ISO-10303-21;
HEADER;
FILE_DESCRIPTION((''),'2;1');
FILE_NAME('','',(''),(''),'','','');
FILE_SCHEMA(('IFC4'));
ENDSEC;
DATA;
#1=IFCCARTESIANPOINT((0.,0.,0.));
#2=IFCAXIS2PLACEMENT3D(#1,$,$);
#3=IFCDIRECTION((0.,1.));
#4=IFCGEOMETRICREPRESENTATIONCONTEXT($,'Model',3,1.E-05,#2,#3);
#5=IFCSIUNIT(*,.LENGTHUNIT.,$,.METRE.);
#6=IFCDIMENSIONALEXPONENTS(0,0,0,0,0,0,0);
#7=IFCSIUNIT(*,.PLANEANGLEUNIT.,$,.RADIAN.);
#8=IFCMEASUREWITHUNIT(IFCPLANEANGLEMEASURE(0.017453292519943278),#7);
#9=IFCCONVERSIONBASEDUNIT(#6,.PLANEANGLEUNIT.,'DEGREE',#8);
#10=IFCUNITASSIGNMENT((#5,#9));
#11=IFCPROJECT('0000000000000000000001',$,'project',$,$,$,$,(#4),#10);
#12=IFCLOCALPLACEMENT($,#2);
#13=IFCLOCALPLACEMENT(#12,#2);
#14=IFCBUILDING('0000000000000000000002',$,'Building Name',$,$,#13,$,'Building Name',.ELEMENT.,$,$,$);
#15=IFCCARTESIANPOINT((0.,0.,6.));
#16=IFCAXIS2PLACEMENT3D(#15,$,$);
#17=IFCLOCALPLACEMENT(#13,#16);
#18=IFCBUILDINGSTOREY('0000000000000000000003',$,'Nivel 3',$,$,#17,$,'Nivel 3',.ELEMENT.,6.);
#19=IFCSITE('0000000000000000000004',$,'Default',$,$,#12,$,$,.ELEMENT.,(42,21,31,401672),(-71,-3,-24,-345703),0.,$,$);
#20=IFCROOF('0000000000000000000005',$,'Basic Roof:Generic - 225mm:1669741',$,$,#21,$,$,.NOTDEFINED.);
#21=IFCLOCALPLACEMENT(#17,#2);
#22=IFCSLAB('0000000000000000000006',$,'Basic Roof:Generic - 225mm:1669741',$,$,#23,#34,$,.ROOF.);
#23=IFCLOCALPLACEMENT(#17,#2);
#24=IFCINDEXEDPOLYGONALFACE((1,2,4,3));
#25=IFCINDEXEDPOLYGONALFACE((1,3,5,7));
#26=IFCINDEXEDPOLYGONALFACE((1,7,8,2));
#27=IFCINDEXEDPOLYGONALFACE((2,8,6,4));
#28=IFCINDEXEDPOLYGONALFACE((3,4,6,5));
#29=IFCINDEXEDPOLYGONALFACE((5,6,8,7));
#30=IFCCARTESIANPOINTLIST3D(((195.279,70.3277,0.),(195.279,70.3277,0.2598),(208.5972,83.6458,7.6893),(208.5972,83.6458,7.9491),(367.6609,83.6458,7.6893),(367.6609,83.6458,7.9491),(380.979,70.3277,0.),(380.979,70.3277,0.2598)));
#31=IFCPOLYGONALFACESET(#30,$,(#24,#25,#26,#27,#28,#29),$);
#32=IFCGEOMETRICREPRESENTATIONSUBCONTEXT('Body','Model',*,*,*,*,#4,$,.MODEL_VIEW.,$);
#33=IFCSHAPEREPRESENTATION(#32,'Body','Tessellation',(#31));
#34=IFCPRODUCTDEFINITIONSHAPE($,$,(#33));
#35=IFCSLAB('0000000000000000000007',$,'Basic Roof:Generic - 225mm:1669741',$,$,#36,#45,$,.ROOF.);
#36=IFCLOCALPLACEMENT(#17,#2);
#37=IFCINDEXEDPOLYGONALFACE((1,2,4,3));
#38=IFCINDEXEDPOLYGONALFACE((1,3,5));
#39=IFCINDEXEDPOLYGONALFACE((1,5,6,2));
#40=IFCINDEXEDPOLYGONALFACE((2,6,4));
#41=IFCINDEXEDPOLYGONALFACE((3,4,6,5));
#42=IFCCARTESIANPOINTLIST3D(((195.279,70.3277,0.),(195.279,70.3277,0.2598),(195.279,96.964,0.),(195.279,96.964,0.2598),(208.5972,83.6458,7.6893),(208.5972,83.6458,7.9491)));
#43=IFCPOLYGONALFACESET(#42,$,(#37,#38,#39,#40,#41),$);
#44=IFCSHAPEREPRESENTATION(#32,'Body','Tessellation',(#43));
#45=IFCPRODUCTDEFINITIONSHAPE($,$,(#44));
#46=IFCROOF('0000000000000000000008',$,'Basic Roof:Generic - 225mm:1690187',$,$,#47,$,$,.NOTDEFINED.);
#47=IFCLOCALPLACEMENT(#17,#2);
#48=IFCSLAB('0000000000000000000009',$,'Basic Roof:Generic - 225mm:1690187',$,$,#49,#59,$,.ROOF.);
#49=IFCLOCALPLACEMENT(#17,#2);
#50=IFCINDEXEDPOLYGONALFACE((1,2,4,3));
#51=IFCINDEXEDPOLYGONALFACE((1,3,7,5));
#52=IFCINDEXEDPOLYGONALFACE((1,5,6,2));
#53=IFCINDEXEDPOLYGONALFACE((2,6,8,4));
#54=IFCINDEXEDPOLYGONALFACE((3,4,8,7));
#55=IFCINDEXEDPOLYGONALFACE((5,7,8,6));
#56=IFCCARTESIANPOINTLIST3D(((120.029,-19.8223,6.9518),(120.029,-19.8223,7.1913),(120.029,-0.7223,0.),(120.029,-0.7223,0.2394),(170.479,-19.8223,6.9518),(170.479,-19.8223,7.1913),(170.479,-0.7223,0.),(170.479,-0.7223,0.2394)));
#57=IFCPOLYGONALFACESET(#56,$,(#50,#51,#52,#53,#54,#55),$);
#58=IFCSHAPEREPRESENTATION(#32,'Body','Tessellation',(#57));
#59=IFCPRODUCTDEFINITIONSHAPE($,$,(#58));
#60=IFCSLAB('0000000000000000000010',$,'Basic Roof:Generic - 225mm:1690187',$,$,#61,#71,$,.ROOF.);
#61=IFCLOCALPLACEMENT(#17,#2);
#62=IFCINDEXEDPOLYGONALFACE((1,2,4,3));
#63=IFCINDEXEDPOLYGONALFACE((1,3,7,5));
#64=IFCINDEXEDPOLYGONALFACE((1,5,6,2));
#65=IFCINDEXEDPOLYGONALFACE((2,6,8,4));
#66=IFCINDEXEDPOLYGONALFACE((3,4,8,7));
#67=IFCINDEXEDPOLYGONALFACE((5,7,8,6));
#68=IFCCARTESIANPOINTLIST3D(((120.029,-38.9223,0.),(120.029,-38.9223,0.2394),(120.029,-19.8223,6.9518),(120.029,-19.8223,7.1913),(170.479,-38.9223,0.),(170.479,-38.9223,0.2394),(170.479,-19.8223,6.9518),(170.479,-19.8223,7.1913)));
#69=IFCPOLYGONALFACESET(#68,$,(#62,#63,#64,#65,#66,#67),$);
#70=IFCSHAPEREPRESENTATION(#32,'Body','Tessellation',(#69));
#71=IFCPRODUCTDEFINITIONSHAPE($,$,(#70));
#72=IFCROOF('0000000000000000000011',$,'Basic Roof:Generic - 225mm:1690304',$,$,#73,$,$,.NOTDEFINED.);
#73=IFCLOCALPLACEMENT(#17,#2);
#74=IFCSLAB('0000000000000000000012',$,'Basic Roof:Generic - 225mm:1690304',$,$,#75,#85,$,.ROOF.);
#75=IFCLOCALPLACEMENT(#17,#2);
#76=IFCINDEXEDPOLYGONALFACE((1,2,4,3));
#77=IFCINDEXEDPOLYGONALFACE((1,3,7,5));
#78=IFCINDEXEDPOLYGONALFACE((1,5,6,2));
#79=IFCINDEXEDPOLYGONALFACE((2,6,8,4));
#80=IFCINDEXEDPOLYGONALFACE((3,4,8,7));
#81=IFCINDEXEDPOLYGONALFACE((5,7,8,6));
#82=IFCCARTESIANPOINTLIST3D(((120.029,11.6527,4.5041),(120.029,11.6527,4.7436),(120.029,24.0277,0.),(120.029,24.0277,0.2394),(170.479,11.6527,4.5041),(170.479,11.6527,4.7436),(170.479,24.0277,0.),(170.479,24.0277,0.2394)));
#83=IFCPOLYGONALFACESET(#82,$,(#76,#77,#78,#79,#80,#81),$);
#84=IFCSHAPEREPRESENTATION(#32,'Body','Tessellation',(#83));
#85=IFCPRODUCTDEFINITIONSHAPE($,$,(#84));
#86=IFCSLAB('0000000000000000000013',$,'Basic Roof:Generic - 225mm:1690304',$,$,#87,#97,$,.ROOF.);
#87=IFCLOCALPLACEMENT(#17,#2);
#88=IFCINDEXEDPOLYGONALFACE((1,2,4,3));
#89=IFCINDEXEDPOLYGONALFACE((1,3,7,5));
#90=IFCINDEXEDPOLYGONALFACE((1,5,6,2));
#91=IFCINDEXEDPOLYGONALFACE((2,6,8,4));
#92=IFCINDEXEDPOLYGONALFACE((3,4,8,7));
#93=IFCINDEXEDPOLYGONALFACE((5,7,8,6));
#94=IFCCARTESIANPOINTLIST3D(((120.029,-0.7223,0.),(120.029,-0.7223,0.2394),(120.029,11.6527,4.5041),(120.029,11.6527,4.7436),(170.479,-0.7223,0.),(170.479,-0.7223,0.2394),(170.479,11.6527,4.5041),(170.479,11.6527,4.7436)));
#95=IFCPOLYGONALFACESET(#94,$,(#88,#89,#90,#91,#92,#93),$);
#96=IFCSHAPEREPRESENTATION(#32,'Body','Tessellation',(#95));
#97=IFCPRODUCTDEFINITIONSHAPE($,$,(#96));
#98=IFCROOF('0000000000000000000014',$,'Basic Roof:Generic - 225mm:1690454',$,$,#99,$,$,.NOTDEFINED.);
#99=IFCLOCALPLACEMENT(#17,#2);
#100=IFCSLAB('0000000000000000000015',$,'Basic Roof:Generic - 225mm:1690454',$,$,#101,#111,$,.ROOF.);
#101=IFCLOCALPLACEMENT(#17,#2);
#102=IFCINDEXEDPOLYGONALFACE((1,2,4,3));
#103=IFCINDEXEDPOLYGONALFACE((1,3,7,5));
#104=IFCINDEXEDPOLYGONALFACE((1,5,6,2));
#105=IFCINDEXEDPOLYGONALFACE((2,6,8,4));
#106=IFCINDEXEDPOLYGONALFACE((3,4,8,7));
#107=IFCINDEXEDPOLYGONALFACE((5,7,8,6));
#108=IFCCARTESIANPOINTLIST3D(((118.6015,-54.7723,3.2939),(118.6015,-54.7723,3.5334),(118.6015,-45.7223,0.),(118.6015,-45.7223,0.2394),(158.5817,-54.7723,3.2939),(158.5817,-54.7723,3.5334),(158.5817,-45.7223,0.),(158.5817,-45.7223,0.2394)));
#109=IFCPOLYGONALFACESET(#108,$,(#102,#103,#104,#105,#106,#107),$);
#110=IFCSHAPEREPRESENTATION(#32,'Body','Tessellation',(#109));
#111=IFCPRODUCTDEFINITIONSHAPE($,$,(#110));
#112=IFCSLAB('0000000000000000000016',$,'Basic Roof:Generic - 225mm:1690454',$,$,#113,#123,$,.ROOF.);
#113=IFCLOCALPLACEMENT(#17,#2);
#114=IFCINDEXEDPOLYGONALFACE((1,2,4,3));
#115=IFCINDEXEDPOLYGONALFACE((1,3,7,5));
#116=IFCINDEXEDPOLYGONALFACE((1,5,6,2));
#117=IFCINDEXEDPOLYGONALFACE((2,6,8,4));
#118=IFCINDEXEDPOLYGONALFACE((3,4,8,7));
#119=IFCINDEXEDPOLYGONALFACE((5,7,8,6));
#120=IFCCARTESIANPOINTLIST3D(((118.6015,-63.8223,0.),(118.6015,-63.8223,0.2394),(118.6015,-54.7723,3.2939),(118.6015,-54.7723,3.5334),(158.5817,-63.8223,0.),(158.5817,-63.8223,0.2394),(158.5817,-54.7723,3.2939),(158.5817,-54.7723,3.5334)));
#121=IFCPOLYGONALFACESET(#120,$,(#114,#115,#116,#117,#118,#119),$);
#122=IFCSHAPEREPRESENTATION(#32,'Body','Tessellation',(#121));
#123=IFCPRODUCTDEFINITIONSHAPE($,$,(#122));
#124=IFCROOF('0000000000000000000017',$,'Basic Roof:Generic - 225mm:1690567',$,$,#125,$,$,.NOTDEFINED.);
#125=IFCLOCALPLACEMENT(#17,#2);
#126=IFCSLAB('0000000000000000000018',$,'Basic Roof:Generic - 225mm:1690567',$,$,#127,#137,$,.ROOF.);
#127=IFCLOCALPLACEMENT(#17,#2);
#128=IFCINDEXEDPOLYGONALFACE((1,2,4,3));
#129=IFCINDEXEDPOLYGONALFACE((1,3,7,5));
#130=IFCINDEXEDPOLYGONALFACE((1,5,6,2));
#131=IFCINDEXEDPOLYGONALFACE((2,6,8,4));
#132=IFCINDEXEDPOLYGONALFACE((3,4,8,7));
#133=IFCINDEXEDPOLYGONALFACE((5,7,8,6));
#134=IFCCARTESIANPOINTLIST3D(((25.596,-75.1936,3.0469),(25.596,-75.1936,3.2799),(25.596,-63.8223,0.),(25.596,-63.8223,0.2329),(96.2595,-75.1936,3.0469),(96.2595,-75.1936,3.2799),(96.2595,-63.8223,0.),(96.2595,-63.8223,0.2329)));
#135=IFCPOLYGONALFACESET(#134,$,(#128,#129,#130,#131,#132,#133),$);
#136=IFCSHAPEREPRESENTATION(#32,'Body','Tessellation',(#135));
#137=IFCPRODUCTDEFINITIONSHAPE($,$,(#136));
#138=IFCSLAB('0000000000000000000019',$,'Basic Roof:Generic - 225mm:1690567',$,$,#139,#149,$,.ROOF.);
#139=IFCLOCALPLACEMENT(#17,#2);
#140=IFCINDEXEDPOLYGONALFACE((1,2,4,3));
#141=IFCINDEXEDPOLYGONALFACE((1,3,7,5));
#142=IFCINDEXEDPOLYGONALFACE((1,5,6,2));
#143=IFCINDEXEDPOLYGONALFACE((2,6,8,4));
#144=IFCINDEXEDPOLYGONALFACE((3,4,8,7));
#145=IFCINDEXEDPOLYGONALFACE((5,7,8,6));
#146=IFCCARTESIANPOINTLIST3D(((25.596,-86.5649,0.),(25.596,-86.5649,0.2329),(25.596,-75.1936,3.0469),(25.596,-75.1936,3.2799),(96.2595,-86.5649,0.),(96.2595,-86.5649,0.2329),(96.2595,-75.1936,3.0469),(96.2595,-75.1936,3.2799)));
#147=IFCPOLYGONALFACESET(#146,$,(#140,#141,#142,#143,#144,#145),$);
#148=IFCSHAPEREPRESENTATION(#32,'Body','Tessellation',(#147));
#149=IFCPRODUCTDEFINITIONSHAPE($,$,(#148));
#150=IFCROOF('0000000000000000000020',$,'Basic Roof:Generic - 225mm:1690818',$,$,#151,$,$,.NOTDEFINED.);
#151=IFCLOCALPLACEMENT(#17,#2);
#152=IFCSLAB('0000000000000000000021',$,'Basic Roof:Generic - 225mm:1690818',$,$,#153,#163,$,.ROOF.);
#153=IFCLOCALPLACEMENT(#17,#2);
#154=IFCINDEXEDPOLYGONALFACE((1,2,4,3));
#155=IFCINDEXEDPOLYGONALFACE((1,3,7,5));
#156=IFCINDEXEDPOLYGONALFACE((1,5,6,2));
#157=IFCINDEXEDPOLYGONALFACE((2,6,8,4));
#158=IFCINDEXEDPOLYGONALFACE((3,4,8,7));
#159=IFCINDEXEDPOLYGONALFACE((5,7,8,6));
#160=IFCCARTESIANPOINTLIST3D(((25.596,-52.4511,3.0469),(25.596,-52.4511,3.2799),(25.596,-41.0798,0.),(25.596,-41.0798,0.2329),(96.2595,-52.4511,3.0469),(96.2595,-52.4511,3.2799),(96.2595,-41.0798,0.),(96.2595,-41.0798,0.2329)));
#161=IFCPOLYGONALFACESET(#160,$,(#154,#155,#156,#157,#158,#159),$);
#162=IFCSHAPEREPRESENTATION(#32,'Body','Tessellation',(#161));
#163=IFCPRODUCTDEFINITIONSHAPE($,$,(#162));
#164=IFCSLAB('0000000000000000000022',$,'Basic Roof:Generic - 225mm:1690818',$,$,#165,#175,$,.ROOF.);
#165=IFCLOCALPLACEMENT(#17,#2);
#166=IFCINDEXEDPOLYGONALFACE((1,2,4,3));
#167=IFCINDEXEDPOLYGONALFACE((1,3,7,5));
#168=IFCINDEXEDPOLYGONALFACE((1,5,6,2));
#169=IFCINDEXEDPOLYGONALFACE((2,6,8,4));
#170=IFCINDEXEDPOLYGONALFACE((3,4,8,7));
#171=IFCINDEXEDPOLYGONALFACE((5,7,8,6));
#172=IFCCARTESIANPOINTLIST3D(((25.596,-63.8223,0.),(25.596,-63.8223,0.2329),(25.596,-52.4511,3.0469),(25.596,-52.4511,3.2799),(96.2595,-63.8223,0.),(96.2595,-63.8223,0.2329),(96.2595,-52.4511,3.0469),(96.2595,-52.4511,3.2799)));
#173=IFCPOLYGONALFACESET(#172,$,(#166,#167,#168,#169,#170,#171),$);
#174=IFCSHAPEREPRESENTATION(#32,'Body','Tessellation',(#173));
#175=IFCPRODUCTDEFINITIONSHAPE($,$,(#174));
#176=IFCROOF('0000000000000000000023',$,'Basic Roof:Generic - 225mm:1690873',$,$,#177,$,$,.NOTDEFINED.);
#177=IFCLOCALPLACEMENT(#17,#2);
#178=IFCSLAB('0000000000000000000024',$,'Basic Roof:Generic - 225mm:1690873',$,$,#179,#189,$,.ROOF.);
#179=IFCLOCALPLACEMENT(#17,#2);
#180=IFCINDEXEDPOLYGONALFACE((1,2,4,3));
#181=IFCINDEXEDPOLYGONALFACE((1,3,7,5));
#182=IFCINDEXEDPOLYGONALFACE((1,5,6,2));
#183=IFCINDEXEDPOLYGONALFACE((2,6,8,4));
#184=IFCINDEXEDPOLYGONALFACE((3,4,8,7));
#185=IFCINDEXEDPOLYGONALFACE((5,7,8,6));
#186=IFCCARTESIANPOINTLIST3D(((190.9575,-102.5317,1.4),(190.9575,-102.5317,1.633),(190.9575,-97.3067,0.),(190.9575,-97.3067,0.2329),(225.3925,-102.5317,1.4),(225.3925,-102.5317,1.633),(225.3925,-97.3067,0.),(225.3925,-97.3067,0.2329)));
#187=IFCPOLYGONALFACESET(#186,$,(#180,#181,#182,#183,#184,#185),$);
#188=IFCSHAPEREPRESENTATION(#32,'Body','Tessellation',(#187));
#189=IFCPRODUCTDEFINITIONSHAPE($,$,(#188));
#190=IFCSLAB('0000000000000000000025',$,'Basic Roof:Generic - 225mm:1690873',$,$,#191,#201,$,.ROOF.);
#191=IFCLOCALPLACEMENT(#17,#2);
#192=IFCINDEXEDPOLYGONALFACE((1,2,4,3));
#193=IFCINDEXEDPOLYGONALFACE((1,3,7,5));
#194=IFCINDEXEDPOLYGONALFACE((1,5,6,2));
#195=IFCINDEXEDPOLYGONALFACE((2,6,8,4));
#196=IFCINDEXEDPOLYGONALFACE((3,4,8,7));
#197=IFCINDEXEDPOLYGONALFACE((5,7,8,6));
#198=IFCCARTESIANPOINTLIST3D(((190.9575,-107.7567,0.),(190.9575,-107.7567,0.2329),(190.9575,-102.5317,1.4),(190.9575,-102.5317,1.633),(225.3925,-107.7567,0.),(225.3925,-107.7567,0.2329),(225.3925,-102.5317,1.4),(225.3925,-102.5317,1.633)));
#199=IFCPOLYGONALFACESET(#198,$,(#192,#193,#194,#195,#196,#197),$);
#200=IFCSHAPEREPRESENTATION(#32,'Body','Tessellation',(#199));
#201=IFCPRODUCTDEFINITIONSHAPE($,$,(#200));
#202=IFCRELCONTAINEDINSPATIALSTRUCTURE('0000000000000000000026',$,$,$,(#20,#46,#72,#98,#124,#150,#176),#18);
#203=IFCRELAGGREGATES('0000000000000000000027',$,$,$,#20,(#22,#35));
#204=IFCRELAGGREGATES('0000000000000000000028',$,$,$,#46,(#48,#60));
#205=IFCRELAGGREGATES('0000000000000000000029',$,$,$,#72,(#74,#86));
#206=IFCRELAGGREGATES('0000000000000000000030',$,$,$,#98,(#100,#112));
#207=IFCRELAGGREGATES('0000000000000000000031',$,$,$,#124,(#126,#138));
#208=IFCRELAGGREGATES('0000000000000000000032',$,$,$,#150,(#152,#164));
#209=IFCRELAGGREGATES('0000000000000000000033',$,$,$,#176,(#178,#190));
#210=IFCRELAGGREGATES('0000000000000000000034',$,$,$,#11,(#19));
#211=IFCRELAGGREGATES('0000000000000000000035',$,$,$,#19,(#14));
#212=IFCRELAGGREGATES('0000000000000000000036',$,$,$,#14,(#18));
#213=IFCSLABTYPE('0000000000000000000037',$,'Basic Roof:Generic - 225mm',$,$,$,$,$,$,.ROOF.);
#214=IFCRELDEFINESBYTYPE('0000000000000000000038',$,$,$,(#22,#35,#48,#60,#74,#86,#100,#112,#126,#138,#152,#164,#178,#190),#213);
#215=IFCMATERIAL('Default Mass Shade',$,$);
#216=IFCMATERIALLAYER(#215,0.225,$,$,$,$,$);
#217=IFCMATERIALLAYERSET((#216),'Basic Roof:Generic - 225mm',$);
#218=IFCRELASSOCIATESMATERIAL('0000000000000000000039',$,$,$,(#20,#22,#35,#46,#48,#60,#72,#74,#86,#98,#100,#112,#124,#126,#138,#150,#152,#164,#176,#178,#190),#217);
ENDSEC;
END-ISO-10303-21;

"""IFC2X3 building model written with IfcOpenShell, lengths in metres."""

from ifc_helpers import new_model, entity, si_unit, converted_unit, direction, frame, frame_2d, origin, place, context, subcontext, project, spatial, polyline, rectangle, outline, extrude, material, layer, layer_set, type_object, element, aggregate, save


model = new_model("IFC2X3")

# Units and contexts
model_context = context("Model", 3, precision=1e-05, world=origin(), true_north=direction((0.0, 1.0)))
body_context = subcontext(model_context, "Body", "Model", "MODEL_VIEW")
ifc_project = project(units=[si_unit("LENGTHUNIT", "METRE"), converted_unit("PLANEANGLEUNIT", "DEGREE", entity("IfcPlaneAngleMeasure", 0.017453292519943278), si_unit("PLANEANGLEUNIT", "RADIAN"), dimensions=[0, 0, 0, 0, 0, 0, 0])], contexts=[model_context])

# Site, building, storey
site_placement = place(None, origin())
site = spatial("IfcSite", under=ifc_project, at=site_placement, Name="Default", CompositionType="ELEMENT", RefLatitude=(42, 21, 31, 401672), RefLongitude=(-71, -3, -24, -345703), RefElevation=0.0)
building_placement = place(site_placement, origin())
building = spatial("IfcBuilding", under=site, at=building_placement, Name="Building Name", LongName="Building Name", CompositionType="ELEMENT")
storey_placement = place(building_placement, frame((0.0, 0.0, 6.0)))
storey = spatial("IfcBuildingStorey", under=building, at=storey_placement, Name="Nivel 3", LongName="Nivel 3", CompositionType="ELEMENT", Elevation=6.0)

# Roofs, slabs
ifc_material_1 = material(Name="Default Mass Shade")
ifc_layer_1 = layer(ifc_material_1, 0.225)
ifc_layer_set_1 = layer_set([ifc_layer_1], Name="Basic Roof:Generic - 225mm")
roof_1_placement = place(storey_placement, frame((195.279, 70.3277, 0.0)))
roof_1 = element("IfcRoof", 1, at=roof_1_placement, inside=storey, material=ifc_layer_set_1, Name="Basic Roof:Generic - 225mm:1669741", ShapeType="NOTDEFINED")
slab_type = type_object("IfcSlabType", Name="Basic Roof:Generic - 225mm", PredefinedType="ROOF")
slab_1_placement = place(roof_1_placement, origin())
slab_1 = element("IfcSlab", 2, at=slab_1_placement, type_object=slab_type, material=ifc_layer_set_1, Name="Basic Roof:Generic - 225mm:1669741", PredefinedType="ROOF", context=body_context, shape_type="SweptSolid", body=[
    extrude(outline(polyline([(-92.85, -7.6893), (92.85, -7.6893), (79.5318, 7.6893), (-79.5318, 7.6893), (-92.85, -7.6893)])), frame((92.85, 6.6591, 3.8446), z_axis=(0.0, -0.5, 0.866025), x_axis=(1.0, 0.0, 0.0)), (0.0, 0.5, 0.866025), 0.2598),
])
slab_2_placement = place(roof_1_placement, origin())
slab_2 = element("IfcSlab", 3, at=slab_2_placement, type_object=slab_type, material=ifc_layer_set_1, Name="Basic Roof:Generic - 225mm:1669741", PredefinedType="ROOF", context=body_context, shape_type="SweptSolid", body=[
    extrude(outline(polyline([(7.6893, 0.0), (-7.6893, 13.3182), (-7.6893, -13.3182), (7.6893, 0.0)])), frame((6.6591, 13.3182, 3.8446), z_axis=(-0.5, 0.0, 0.866025), x_axis=(0.866025, 0.0, 0.5)), (0.5, 0.0, 0.866025), 0.2598),
])
aggregate(roof_1, [slab_1, slab_2])
roof_2_placement = place(storey_placement, frame((120.029, -38.9223, 0.0)))
roof_2 = element("IfcRoof", 4, at=roof_2_placement, inside=storey, material=ifc_layer_set_1, Name="Basic Roof:Generic - 225mm:1690187", ShapeType="NOTDEFINED")
slab_3_placement = place(roof_2_placement, origin())
slab_3 = element("IfcSlab", 5, at=slab_3_placement, type_object=slab_type, material=ifc_layer_set_1, Name="Basic Roof:Generic - 225mm:1690187", PredefinedType="ROOF", context=body_context, shape_type="SweptSolid", body=[
    extrude(rectangle(XDim=20.3258, YDim=50.45, at=frame_2d((0.0, 0.0), x_axis=(0.0, -1.0))), frame((25.225, 28.65, 3.4759), z_axis=(0.0, 0.34202, 0.939693), x_axis=(1.0, 0.0, 0.0)), (0.0, -0.34202, 0.939693), 0.2394),
])
slab_4_placement = place(roof_2_placement, origin())
slab_4 = element("IfcSlab", 6, at=slab_4_placement, type_object=slab_type, material=ifc_layer_set_1, Name="Basic Roof:Generic - 225mm:1690187", PredefinedType="ROOF", context=body_context, shape_type="SweptSolid", body=[
    extrude(rectangle(XDim=50.45, YDim=20.3258, at=frame_2d((0.0, 0.0), x_axis=(-1.0, 0.0))), frame((25.225, 9.55, 3.4759), z_axis=(0.0, -0.34202, 0.939693), x_axis=(1.0, 0.0, 0.0)), (0.0, 0.34202, 0.939693), 0.2394),
])
aggregate(roof_2, [slab_3, slab_4])
roof_3_placement = place(storey_placement, frame((120.029, -0.7223, 0.0)))
roof_3 = element("IfcRoof", 7, at=roof_3_placement, inside=storey, material=ifc_layer_set_1, Name="Basic Roof:Generic - 225mm:1690304", ShapeType="NOTDEFINED")
slab_5_placement = place(roof_3_placement, origin())
slab_5 = element("IfcSlab", 8, at=slab_5_placement, type_object=slab_type, material=ifc_layer_set_1, Name="Basic Roof:Generic - 225mm:1690304", PredefinedType="ROOF", context=body_context, shape_type="SweptSolid", body=[
    extrude(rectangle(XDim=13.1692, YDim=50.45, at=frame_2d((0.0, 0.0), x_axis=(0.0, -1.0))), frame((25.225, 18.5625, 2.2521), z_axis=(0.0, 0.34202, 0.939693), x_axis=(1.0, 0.0, 0.0)), (0.0, -0.34202, 0.939693), 0.2394),
])
slab_6_placement = place(roof_3_placement, origin())
slab_6 = element("IfcSlab", 9, at=slab_6_placement, type_object=slab_type, material=ifc_layer_set_1, Name="Basic Roof:Generic - 225mm:1690304", PredefinedType="ROOF", context=body_context, shape_type="SweptSolid", body=[
    extrude(rectangle(XDim=50.45, YDim=13.1692, at=frame_2d((0.0, 0.0), x_axis=(-1.0, 0.0))), frame((25.225, 6.1875, 2.2521), z_axis=(0.0, -0.34202, 0.939693), x_axis=(1.0, 0.0, 0.0)), (0.0, 0.34202, 0.939693), 0.2394),
])
aggregate(roof_3, [slab_5, slab_6])
roof_4_placement = place(storey_placement, frame((118.6015, -63.8223, 0.0)))
roof_4 = element("IfcRoof", 10, at=roof_4_placement, inside=storey, material=ifc_layer_set_1, Name="Basic Roof:Generic - 225mm:1690454", ShapeType="NOTDEFINED")
slab_7_placement = place(roof_4_placement, origin())
slab_7 = element("IfcSlab", 11, at=slab_7_placement, type_object=slab_type, material=ifc_layer_set_1, Name="Basic Roof:Generic - 225mm:1690454", PredefinedType="ROOF", context=body_context, shape_type="SweptSolid", body=[
    extrude(rectangle(XDim=39.9802, YDim=9.6308, at=frame_2d((0.0, 0.0), x_axis=(1.0, 0.0))), frame((19.9901, 13.575, 1.647), z_axis=(0.0, 0.34202, 0.939693), x_axis=(1.0, 0.0, 0.0)), (0.0, -0.34202, 0.939693), 0.2394),
])
slab_8_placement = place(roof_4_placement, origin())
slab_8 = element("IfcSlab", 12, at=slab_8_placement, type_object=slab_type, material=ifc_layer_set_1, Name="Basic Roof:Generic - 225mm:1690454", PredefinedType="ROOF", context=body_context, shape_type="SweptSolid", body=[
    extrude(rectangle(XDim=9.6308, YDim=39.9802, at=frame_2d((0.0, 0.0), x_axis=(0.0, 1.0))), frame((19.9901, 4.525, 1.647), z_axis=(0.0, -0.34202, 0.939693), x_axis=(1.0, 0.0, 0.0)), (0.0, 0.34202, 0.939693), 0.2394),
])
aggregate(roof_4, [slab_7, slab_8])
roof_5_placement = place(storey_placement, frame((25.596, -86.5649, 0.0)))
roof_5 = element("IfcRoof", 13, at=roof_5_placement, inside=storey, material=ifc_layer_set_1, Name="Basic Roof:Generic - 225mm:1690567", ShapeType="NOTDEFINED")
slab_9_placement = place(roof_5_placement, origin())
slab_9 = element("IfcSlab", 14, at=slab_9_placement, type_object=slab_type, material=ifc_layer_set_1, Name="Basic Roof:Generic - 225mm:1690567", PredefinedType="ROOF", context=body_context, shape_type="SweptSolid", body=[
    extrude(rectangle(XDim=11.7724, YDim=70.6635, at=frame_2d((0.0, 0.0), x_axis=(0.0, -1.0))), frame((35.3318, 17.0569, 1.5235), z_axis=(0.0, 0.258819, 0.965926), x_axis=(1.0, 0.0, 0.0)), (0.0, -0.258819, 0.965926), 0.2329),
])
slab_10_placement = place(roof_5_placement, origin())
slab_10 = element("IfcSlab", 15, at=slab_10_placement, type_object=slab_type, material=ifc_layer_set_1, Name="Basic Roof:Generic - 225mm:1690567", PredefinedType="ROOF", context=body_context, shape_type="SweptSolid", body=[
    extrude(rectangle(XDim=70.6635, YDim=11.7724, at=frame_2d((0.0, 0.0), x_axis=(-1.0, 0.0))), frame((35.3318, 5.6856, 1.5235), z_axis=(0.0, -0.258819, 0.965926), x_axis=(1.0, 0.0, 0.0)), (0.0, 0.258819, 0.965926), 0.2329),
])
aggregate(roof_5, [slab_9, slab_10])
roof_6_placement = place(storey_placement, frame((25.596, -63.8223, 0.0)))
roof_6 = element("IfcRoof", 16, at=roof_6_placement, inside=storey, material=ifc_layer_set_1, Name="Basic Roof:Generic - 225mm:1690818", ShapeType="NOTDEFINED")
slab_11_placement = place(roof_6_placement, origin())
slab_11 = element("IfcSlab", 17, at=slab_11_placement, type_object=slab_type, material=ifc_layer_set_1, Name="Basic Roof:Generic - 225mm:1690818", PredefinedType="ROOF", context=body_context, shape_type="SweptSolid", body=[
    extrude(rectangle(XDim=11.7724, YDim=70.6635, at=frame_2d((0.0, 0.0), x_axis=(0.0, -1.0))), frame((35.3318, 17.0569, 1.5235), z_axis=(0.0, 0.258819, 0.965926), x_axis=(1.0, 0.0, 0.0)), (0.0, -0.258819, 0.965926), 0.2329),
])
slab_12_placement = place(roof_6_placement, origin())
slab_12 = element("IfcSlab", 18, at=slab_12_placement, type_object=slab_type, material=ifc_layer_set_1, Name="Basic Roof:Generic - 225mm:1690818", PredefinedType="ROOF", context=body_context, shape_type="SweptSolid", body=[
    extrude(rectangle(XDim=70.6635, YDim=11.7724, at=frame_2d((0.0, 0.0), x_axis=(-1.0, 0.0))), frame((35.3318, 5.6856, 1.5235), z_axis=(0.0, -0.258819, 0.965926), x_axis=(1.0, 0.0, 0.0)), (0.0, 0.258819, 0.965926), 0.2329),
])
aggregate(roof_6, [slab_11, slab_12])
roof_7_placement = place(storey_placement, frame((190.9575, -107.7567, 0.0)))
roof_7 = element("IfcRoof", 19, at=roof_7_placement, inside=storey, material=ifc_layer_set_1, Name="Basic Roof:Generic - 225mm:1690873", ShapeType="NOTDEFINED")
slab_13_placement = place(roof_7_placement, origin())
slab_13 = element("IfcSlab", 20, at=slab_13_placement, type_object=slab_type, material=ifc_layer_set_1, Name="Basic Roof:Generic - 225mm:1690873", PredefinedType="ROOF", context=body_context, shape_type="SweptSolid", body=[
    extrude(rectangle(XDim=5.4093, YDim=34.435, at=frame_2d((0.0, 0.0), x_axis=(0.0, -1.0))), frame((17.2175, 7.8375, 0.7), z_axis=(0.0, 0.258819, 0.965926), x_axis=(1.0, 0.0, 0.0)), (0.0, -0.258819, 0.965926), 0.2329),
])
slab_14_placement = place(roof_7_placement, origin())
slab_14 = element("IfcSlab", 21, at=slab_14_placement, type_object=slab_type, material=ifc_layer_set_1, Name="Basic Roof:Generic - 225mm:1690873", PredefinedType="ROOF", context=body_context, shape_type="SweptSolid", body=[
    extrude(rectangle(XDim=34.435, YDim=5.4093, at=frame_2d((0.0, 0.0), x_axis=(-1.0, 0.0))), frame((17.2175, 2.6125, 0.7), z_axis=(0.0, -0.258819, 0.965926), x_axis=(1.0, 0.0, 0.0)), (0.0, 0.258819, 0.965926), 0.2329),
])
aggregate(roof_7, [slab_13, slab_14])

save(model, "model.ifc")
